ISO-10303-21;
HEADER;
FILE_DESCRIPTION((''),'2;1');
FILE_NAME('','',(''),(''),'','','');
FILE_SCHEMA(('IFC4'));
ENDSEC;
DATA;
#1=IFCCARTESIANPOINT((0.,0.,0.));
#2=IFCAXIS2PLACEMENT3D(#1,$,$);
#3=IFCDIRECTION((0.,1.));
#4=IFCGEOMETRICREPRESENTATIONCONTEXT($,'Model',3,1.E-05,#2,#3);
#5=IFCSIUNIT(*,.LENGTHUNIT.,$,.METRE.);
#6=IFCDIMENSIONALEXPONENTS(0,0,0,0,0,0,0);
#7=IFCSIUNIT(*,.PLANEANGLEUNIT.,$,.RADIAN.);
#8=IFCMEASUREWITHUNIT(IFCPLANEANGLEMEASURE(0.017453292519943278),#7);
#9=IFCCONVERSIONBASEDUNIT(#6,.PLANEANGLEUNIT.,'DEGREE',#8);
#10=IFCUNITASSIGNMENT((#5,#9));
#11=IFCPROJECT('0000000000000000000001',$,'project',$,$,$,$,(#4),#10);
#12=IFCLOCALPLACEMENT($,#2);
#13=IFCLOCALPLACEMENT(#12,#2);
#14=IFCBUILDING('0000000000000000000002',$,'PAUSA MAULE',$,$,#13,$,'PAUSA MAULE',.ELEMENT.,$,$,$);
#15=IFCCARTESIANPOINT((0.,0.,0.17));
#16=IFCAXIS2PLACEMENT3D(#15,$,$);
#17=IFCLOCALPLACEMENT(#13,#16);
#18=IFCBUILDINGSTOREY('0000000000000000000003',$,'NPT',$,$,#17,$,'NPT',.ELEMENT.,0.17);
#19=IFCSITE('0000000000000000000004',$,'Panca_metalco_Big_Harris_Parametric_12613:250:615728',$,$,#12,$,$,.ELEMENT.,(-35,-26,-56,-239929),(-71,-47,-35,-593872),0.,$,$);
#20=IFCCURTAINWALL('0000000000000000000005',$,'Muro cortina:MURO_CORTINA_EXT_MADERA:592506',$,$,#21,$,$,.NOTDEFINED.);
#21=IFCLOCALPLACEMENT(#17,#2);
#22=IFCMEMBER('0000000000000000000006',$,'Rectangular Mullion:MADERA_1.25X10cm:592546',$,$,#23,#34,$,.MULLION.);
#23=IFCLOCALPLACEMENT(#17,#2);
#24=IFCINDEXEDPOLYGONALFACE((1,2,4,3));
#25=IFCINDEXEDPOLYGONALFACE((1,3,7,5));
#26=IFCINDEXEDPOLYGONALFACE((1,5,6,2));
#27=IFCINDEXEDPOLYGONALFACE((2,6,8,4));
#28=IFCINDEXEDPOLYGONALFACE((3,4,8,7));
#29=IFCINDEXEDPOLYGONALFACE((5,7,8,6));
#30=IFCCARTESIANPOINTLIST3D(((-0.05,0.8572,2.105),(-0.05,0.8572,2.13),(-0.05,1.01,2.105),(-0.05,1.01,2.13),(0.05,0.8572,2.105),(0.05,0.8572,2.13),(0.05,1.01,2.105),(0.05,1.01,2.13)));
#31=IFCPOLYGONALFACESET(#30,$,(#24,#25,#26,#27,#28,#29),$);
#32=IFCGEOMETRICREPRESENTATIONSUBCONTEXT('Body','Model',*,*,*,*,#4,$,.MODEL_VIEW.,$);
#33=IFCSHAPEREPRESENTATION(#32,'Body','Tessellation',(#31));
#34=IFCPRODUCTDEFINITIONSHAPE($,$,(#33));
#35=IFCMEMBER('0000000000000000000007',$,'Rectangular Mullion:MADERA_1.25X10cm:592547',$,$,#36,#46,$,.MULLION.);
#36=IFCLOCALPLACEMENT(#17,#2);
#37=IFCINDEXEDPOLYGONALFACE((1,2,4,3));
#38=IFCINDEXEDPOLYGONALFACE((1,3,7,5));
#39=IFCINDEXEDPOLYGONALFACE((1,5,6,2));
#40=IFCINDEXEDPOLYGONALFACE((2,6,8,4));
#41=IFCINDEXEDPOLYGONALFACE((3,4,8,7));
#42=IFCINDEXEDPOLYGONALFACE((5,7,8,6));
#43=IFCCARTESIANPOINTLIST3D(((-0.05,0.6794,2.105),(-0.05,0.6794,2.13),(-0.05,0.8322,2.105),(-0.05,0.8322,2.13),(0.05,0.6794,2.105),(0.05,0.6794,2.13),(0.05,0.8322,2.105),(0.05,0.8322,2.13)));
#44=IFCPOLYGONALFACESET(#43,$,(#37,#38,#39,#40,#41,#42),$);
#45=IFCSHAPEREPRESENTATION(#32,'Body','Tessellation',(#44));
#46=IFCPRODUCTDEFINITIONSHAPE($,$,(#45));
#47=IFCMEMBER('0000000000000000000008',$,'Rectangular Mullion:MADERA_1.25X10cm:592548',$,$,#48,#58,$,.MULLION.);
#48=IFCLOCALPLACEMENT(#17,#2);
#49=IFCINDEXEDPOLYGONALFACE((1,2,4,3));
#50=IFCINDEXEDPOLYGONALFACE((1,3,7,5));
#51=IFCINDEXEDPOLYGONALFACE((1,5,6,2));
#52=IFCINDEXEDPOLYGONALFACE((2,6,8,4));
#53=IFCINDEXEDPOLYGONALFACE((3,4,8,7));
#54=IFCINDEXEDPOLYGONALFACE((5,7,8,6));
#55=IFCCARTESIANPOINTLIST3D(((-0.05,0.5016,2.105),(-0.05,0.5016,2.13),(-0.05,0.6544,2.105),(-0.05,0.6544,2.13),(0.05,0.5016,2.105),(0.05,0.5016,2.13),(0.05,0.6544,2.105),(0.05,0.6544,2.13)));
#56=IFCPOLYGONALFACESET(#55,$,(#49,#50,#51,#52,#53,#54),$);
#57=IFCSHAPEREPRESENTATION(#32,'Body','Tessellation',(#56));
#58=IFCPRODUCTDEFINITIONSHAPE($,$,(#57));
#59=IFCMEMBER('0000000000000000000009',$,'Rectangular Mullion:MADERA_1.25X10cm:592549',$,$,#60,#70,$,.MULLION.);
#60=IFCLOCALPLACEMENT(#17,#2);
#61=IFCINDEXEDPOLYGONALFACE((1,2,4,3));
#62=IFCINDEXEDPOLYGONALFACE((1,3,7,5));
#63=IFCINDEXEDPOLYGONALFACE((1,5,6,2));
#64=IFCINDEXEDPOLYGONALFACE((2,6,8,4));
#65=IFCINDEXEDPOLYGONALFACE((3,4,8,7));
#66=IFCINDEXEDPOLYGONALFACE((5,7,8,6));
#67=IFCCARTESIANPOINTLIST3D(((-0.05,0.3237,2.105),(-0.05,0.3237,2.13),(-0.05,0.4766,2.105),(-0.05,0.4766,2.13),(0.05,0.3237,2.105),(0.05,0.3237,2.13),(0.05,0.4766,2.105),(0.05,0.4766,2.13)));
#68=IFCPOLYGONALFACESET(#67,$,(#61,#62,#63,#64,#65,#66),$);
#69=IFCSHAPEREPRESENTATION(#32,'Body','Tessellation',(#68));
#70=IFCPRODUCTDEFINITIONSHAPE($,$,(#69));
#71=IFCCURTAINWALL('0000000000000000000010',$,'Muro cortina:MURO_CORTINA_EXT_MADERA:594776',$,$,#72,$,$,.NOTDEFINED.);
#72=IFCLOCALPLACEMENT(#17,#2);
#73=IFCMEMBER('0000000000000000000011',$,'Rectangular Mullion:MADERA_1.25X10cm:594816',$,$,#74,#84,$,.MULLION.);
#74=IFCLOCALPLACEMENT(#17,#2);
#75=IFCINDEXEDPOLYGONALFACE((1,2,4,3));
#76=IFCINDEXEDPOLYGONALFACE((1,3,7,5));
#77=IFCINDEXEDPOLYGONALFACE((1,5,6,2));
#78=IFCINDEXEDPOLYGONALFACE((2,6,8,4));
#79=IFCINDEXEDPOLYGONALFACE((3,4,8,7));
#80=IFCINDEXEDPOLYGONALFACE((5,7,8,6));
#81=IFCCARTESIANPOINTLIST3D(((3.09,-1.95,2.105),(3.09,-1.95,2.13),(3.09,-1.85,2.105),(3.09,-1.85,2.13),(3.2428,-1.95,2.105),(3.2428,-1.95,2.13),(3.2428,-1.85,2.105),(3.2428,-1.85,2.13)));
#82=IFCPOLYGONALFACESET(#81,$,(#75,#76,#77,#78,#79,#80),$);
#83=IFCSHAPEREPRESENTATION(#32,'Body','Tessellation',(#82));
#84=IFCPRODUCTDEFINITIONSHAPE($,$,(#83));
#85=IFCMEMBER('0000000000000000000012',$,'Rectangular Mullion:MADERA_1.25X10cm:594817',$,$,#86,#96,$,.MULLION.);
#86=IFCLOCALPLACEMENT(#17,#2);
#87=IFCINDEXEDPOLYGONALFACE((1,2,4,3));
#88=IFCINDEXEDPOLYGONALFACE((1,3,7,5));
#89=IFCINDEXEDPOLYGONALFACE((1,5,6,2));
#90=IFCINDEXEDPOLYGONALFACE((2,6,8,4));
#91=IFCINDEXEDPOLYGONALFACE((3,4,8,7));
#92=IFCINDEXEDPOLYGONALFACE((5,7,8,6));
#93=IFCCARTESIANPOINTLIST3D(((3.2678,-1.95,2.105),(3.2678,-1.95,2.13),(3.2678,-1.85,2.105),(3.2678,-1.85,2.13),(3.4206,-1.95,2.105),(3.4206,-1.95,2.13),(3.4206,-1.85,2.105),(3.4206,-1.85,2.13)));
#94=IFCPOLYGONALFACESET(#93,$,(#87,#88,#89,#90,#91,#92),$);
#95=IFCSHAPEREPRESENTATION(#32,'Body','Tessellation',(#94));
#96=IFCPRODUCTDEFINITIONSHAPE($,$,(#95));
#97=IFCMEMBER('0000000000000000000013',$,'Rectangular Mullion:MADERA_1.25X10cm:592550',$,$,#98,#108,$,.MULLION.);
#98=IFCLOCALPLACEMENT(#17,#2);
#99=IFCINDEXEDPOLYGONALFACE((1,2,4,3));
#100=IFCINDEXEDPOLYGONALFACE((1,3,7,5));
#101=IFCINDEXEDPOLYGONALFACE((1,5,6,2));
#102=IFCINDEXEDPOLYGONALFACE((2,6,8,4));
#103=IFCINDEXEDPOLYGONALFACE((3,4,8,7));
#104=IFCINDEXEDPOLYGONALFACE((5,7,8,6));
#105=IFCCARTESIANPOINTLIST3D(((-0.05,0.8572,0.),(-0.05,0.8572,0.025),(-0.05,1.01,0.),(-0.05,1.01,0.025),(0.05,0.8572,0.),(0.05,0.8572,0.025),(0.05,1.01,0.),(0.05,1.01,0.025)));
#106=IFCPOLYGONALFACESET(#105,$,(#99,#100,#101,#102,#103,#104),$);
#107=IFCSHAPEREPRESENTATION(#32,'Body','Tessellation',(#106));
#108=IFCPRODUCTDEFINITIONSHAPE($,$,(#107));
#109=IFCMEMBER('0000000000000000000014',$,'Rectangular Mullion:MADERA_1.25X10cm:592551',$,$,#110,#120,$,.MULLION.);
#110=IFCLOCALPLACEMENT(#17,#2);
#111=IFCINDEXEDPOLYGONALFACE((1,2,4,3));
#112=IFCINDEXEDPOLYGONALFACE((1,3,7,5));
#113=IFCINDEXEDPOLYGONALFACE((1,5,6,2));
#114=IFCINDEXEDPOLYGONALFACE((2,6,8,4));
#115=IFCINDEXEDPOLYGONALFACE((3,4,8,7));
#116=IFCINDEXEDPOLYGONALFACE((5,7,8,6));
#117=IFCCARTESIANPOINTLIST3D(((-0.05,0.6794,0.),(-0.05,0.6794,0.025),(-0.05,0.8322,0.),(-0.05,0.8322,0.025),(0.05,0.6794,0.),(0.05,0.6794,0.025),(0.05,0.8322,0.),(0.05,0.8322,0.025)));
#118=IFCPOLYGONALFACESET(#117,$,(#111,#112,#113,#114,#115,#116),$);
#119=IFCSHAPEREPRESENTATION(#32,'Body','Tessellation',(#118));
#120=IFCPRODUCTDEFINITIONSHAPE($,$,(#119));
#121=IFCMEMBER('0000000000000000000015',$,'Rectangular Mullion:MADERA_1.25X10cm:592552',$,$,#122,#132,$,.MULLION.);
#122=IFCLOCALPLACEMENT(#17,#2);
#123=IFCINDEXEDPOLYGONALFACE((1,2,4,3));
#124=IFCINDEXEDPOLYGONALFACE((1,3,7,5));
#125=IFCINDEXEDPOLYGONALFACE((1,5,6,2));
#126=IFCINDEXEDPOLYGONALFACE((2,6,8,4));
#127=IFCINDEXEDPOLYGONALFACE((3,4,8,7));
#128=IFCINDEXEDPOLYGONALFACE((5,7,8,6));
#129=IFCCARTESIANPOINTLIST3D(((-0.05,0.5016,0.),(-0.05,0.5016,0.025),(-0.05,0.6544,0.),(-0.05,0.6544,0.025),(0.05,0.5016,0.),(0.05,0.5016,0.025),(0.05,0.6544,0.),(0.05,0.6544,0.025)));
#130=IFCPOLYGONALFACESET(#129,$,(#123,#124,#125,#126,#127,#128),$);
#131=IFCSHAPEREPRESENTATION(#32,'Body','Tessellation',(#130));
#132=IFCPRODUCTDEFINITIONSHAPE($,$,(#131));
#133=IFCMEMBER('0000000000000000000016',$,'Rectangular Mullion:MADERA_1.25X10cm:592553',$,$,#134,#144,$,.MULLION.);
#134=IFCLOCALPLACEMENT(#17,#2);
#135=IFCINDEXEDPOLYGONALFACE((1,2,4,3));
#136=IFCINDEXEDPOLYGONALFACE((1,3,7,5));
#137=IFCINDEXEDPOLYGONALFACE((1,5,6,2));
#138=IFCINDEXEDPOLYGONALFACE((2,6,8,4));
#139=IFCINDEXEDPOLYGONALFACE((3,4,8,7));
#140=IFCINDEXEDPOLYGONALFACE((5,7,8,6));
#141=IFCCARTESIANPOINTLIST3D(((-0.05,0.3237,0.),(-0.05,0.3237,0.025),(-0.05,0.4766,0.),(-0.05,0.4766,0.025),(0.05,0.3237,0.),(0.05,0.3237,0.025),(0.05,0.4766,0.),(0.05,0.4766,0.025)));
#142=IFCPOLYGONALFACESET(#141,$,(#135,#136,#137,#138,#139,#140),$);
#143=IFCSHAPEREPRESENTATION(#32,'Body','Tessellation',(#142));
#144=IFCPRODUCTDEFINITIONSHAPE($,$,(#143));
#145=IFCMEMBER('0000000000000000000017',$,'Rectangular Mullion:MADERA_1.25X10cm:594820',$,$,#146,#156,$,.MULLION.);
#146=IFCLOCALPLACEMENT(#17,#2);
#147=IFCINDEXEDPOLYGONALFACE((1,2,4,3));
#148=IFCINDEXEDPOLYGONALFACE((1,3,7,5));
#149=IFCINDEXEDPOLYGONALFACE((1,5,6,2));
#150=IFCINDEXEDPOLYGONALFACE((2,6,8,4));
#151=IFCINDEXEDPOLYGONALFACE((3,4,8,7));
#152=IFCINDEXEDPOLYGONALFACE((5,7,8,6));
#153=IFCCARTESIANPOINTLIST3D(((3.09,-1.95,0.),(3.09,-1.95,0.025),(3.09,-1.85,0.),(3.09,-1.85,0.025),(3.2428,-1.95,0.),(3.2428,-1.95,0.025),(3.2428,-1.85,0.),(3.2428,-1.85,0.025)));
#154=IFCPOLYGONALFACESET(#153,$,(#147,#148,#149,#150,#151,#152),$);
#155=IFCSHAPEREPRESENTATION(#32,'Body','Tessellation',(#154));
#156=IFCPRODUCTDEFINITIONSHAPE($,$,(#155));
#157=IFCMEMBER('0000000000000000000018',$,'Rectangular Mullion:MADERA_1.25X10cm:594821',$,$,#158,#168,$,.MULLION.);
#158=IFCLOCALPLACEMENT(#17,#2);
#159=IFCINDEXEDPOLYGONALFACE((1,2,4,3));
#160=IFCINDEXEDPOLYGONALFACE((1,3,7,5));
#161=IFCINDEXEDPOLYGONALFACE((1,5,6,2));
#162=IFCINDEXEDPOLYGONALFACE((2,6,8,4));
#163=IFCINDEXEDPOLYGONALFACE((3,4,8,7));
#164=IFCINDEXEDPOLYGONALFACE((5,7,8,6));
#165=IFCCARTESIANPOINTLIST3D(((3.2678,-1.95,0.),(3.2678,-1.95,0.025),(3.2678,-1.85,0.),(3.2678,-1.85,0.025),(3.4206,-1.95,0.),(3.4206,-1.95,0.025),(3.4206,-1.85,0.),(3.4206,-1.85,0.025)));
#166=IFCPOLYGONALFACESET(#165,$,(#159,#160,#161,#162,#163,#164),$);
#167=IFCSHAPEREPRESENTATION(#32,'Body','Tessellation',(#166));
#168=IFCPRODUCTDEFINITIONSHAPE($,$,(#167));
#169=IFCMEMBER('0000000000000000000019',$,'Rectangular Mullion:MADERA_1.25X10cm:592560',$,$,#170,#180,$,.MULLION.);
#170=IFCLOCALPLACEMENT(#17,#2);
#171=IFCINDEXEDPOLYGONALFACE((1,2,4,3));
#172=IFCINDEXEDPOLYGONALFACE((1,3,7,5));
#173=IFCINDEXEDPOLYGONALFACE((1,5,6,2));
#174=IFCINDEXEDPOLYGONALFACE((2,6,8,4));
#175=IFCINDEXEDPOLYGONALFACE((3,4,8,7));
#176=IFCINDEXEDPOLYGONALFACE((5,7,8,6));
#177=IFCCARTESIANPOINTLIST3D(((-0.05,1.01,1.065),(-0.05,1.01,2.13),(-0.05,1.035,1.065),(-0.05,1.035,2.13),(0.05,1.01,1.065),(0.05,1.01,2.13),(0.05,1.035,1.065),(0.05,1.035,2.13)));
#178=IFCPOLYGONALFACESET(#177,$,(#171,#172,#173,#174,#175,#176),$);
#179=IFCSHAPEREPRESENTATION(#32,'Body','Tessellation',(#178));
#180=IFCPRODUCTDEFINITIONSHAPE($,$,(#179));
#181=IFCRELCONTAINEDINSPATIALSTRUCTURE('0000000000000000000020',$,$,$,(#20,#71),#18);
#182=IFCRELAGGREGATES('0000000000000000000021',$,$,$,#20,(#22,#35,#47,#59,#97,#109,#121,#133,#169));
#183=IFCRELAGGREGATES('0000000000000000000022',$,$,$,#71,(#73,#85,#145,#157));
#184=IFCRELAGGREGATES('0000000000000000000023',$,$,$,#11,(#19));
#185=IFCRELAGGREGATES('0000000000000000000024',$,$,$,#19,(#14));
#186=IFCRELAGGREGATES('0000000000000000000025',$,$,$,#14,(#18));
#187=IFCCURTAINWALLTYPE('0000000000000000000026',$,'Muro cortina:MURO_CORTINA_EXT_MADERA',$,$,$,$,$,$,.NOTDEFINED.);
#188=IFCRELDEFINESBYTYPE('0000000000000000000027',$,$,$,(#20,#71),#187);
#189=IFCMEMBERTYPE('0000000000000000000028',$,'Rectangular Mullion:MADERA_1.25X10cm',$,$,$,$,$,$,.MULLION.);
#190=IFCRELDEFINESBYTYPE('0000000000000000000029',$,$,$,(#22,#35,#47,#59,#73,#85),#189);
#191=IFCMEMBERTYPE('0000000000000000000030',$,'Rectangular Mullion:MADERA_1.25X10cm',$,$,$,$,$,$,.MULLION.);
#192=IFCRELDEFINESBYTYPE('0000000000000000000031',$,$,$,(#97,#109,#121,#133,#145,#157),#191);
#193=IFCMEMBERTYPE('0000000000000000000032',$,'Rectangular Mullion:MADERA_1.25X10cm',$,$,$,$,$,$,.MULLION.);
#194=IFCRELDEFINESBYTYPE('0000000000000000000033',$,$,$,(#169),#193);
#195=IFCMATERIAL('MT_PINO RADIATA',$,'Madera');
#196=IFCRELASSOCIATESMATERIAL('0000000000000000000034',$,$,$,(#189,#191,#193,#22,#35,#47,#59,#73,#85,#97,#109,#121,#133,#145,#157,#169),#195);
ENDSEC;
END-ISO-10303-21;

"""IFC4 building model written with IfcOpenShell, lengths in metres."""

from ifc_helpers import new_model, entity, si_unit, converted_unit, direction, frame, frame_2d, origin, place, context, subcontext, project, spatial, rectangle, extrude, source, transform, mapped, material, material_profile, profile_set, profile_usage, type_object, type_shapes, element, aggregate, save


model = new_model("IFC4")

# Units and contexts
model_context = context("Model", 3, precision=1e-05, world=origin(), true_north=direction((0.0, 1.0)))
body_context = subcontext(model_context, "Body", "Model", "MODEL_VIEW")
ifc_project = project(units=[si_unit("LENGTHUNIT", "METRE"), converted_unit("PLANEANGLEUNIT", "DEGREE", entity("IfcPlaneAngleMeasure", 0.017453292519943278), si_unit("PLANEANGLEUNIT", "RADIAN"), dimensions=[0, 0, 0, 0, 0, 0, 0])], contexts=[model_context])

# Site, building, storey
site_placement = place(None, origin())
site = spatial("IfcSite", under=ifc_project, at=site_placement, Name="Panca_metalco_Big_Harris_Parametric_12613:250:615728", CompositionType="ELEMENT", RefLatitude=(-35, -26, -56, -239929), RefLongitude=(-71, -47, -35, -593872), RefElevation=0.0)
building_placement = place(site_placement, origin())
building = spatial("IfcBuilding", under=site, at=building_placement, Name="PAUSA MAULE", LongName="PAUSA MAULE", CompositionType="ELEMENT")
storey_placement = place(building_placement, frame((0.0, 0.0, 0.17)))
storey = spatial("IfcBuildingStorey", under=building, at=storey_placement, Name="NPT", LongName="NPT", CompositionType="ELEMENT", Elevation=0.17)

# Curtain walls, members
curtain_wall_type = type_object("IfcCurtainWallType", Name="Muro cortina:MURO_CORTINA_EXT_MADERA", PredefinedType="NOTDEFINED")
curtain_wall_1_placement = place(storey_placement, frame((0.0, 0.0, -0.17)))
curtain_wall_1 = element("IfcCurtainWall", 1, at=curtain_wall_1_placement, inside=storey, type_object=curtain_wall_type, Name="Muro cortina:MURO_CORTINA_EXT_MADERA:592506", PredefinedType="NOTDEFINED")
ifc_material = material(Name="MT_PINO RADIATA", Category="Madera")
ifc_material_profile = material_profile(ifc_material, rectangle(XDim=0.025, YDim=0.1, at=frame_2d((0.0, 0.0), x_axis=(1.0, 0.0))), Name="MADERA_1.25X10cm")
ifc_profile_set = profile_set([ifc_material_profile], Name="MADERA_1.25X10cm")
ifc_profile_usage = profile_usage(ifc_profile_set)
member_type_1 = type_object("IfcMemberType", Name="Rectangular Mullion:MADERA_1.25X10cm", PredefinedType="MULLION", material=ifc_profile_set)
shared_shape_1 = source(origin(), body_context, "Body", "SweptSolid", [
    extrude(rectangle(XDim=0.025, YDim=0.1, at=frame_2d((0.0, 0.0), x_axis=(1.0, 0.0))), frame((-0.0125, 0.0, -0.1528), z_axis=(0.0, 0.0, 1.0), x_axis=(-1.0, 0.0, 0.0)), (0.0, 0.0, 1.0), 0.1528),
])
type_shapes(member_type_1, [shared_shape_1])
member_1_placement = place(curtain_wall_1_placement, frame((0.0, 0.8572, 2.3), z_axis=(0.0, -1.0, 0.0), x_axis=(0.0, 0.0, 1.0)))
member_1 = element("IfcMember", 2, at=member_1_placement, type_object=member_type_1, material=ifc_profile_usage, Name="Rectangular Mullion:MADERA_1.25X10cm:592546", PredefinedType="MULLION", context=body_context, shape_type="MappedRepresentation", body=[
    mapped(shared_shape_1, transform((0.0, 0.0, 0.0), scale=1.0)),
])
member_2_placement = place(curtain_wall_1_placement, frame((0.0, 0.6794, 2.3), z_axis=(0.0, -1.0, 0.0), x_axis=(0.0, 0.0, 1.0)))
member_2 = element("IfcMember", 3, at=member_2_placement, type_object=member_type_1, material=ifc_profile_usage, Name="Rectangular Mullion:MADERA_1.25X10cm:592547", PredefinedType="MULLION", context=body_context, shape_type="MappedRepresentation", body=[
    mapped(shared_shape_1, transform((0.0, 0.0, 0.0), scale=1.0)),
])
member_3_placement = place(curtain_wall_1_placement, frame((0.0, 0.5016, 2.3), z_axis=(0.0, -1.0, 0.0), x_axis=(0.0, 0.0, 1.0)))
member_3 = element("IfcMember", 4, at=member_3_placement, type_object=member_type_1, material=ifc_profile_usage, Name="Rectangular Mullion:MADERA_1.25X10cm:592548", PredefinedType="MULLION", context=body_context, shape_type="MappedRepresentation", body=[
    mapped(shared_shape_1, transform((0.0, 0.0, 0.0), scale=1.0)),
])
member_4_placement = place(curtain_wall_1_placement, frame((0.0, 0.3237, 2.3), z_axis=(0.0, -1.0, 0.0), x_axis=(0.0, 0.0, 1.0)))
member_4 = element("IfcMember", 5, at=member_4_placement, type_object=member_type_1, material=ifc_profile_usage, Name="Rectangular Mullion:MADERA_1.25X10cm:592549", PredefinedType="MULLION", context=body_context, shape_type="MappedRepresentation", body=[
    mapped(shared_shape_1, transform((0.0, 0.0, 0.0), scale=1.0)),
])
curtain_wall_2_placement = place(storey_placement, frame((0.0, 0.0, -0.17)))
curtain_wall_2 = element("IfcCurtainWall", 6, at=curtain_wall_2_placement, inside=storey, type_object=curtain_wall_type, Name="Muro cortina:MURO_CORTINA_EXT_MADERA:594776", PredefinedType="NOTDEFINED")
member_5_placement = place(curtain_wall_2_placement, frame((3.2428, -1.9, 2.3), z_axis=(1.0, 0.0, 0.0), x_axis=(0.0, 0.0, 1.0)))
member_5 = element("IfcMember", 7, at=member_5_placement, type_object=member_type_1, material=ifc_profile_usage, Name="Rectangular Mullion:MADERA_1.25X10cm:594816", PredefinedType="MULLION", context=body_context, shape_type="MappedRepresentation", body=[
    mapped(shared_shape_1, transform((0.0, 0.0, 0.0), scale=1.0)),
])
member_6_placement = place(curtain_wall_2_placement, frame((3.4206, -1.9, 2.3), z_axis=(1.0, 0.0, 0.0), x_axis=(0.0, 0.0, 1.0)))
member_6 = element("IfcMember", 8, at=member_6_placement, type_object=member_type_1, material=ifc_profile_usage, Name="Rectangular Mullion:MADERA_1.25X10cm:594817", PredefinedType="MULLION", context=body_context, shape_type="MappedRepresentation", body=[
    mapped(shared_shape_1, transform((0.0, 0.0, 0.0), scale=1.0)),
])

# Members
member_type_2 = type_object("IfcMemberType", Name="Rectangular Mullion:MADERA_1.25X10cm", PredefinedType="MULLION", material=ifc_profile_set)
shared_shape_2 = source(origin(), body_context, "Body", "SweptSolid", [
    extrude(rectangle(XDim=0.025, YDim=0.1, at=frame_2d((0.0, 0.0), x_axis=(1.0, 0.0))), frame((-0.0125, 0.0, -0.1528), z_axis=(0.0, 0.0, 1.0), x_axis=(-1.0, 0.0, 0.0)), (0.0, 0.0, 1.0), 0.1528),
])
type_shapes(member_type_2, [shared_shape_2])
member_7_placement = place(curtain_wall_1_placement, frame((0.0, 1.01, 0.17), z_axis=(0.0, 1.0, 0.0), x_axis=(0.0, 0.0, -1.0)))
member_7 = element("IfcMember", 9, at=member_7_placement, type_object=member_type_2, material=ifc_profile_usage, Name="Rectangular Mullion:MADERA_1.25X10cm:592550", PredefinedType="MULLION", context=body_context, shape_type="MappedRepresentation", body=[
    mapped(shared_shape_2, transform((0.0, 0.0, 0.0), scale=1.0)),
])
member_8_placement = place(curtain_wall_1_placement, frame((0.0, 0.8322, 0.17), z_axis=(0.0, 1.0, 0.0), x_axis=(0.0, 0.0, -1.0)))
member_8 = element("IfcMember", 10, at=member_8_placement, type_object=member_type_2, material=ifc_profile_usage, Name="Rectangular Mullion:MADERA_1.25X10cm:592551", PredefinedType="MULLION", context=body_context, shape_type="MappedRepresentation", body=[
    mapped(shared_shape_2, transform((0.0, 0.0, 0.0), scale=1.0)),
])
member_9_placement = place(curtain_wall_1_placement, frame((0.0, 0.6544, 0.17), z_axis=(0.0, 1.0, 0.0), x_axis=(0.0, 0.0, -1.0)))
member_9 = element("IfcMember", 11, at=member_9_placement, type_object=member_type_2, material=ifc_profile_usage, Name="Rectangular Mullion:MADERA_1.25X10cm:592552", PredefinedType="MULLION", context=body_context, shape_type="MappedRepresentation", body=[
    mapped(shared_shape_2, transform((0.0, 0.0, 0.0), scale=1.0)),
])
member_10_placement = place(curtain_wall_1_placement, frame((0.0, 0.4766, 0.17), z_axis=(0.0, 1.0, 0.0), x_axis=(0.0, 0.0, -1.0)))
member_10 = element("IfcMember", 12, at=member_10_placement, type_object=member_type_2, material=ifc_profile_usage, Name="Rectangular Mullion:MADERA_1.25X10cm:592553", PredefinedType="MULLION", context=body_context, shape_type="MappedRepresentation", body=[
    mapped(shared_shape_2, transform((0.0, 0.0, 0.0), scale=1.0)),
])
member_11_placement = place(curtain_wall_2_placement, frame((3.09, -1.9, 0.17), z_axis=(-1.0, 0.0, 0.0), x_axis=(0.0, 0.0, -1.0)))
member_11 = element("IfcMember", 13, at=member_11_placement, type_object=member_type_2, material=ifc_profile_usage, Name="Rectangular Mullion:MADERA_1.25X10cm:594820", PredefinedType="MULLION", context=body_context, shape_type="MappedRepresentation", body=[
    mapped(shared_shape_2, transform((0.0, 0.0, 0.0), scale=1.0)),
])
member_12_placement = place(curtain_wall_2_placement, frame((3.2678, -1.9, 0.17), z_axis=(-1.0, 0.0, 0.0), x_axis=(0.0, 0.0, -1.0)))
member_12 = element("IfcMember", 14, at=member_12_placement, type_object=member_type_2, material=ifc_profile_usage, Name="Rectangular Mullion:MADERA_1.25X10cm:594821", PredefinedType="MULLION", context=body_context, shape_type="MappedRepresentation", body=[
    mapped(shared_shape_2, transform((0.0, 0.0, 0.0), scale=1.0)),
])
member_type_3 = type_object("IfcMemberType", Name="Rectangular Mullion:MADERA_1.25X10cm", PredefinedType="MULLION", material=ifc_profile_set)
shared_shape_3 = source(origin(), body_context, "Body", "SweptSolid", [
    extrude(rectangle(XDim=0.025, YDim=0.1, at=frame_2d((0.0, 0.0), x_axis=(1.0, 0.0))), frame((-0.0125, 0.0, -1.065), z_axis=(0.0, 0.0, 1.0), x_axis=(-1.0, 0.0, 0.0)), (0.0, 0.0, 1.0), 1.065),
])
type_shapes(member_type_3, [shared_shape_3])
member_13_placement = place(curtain_wall_1_placement, frame((0.0, 1.035, 2.3), z_axis=(0.0, 0.0, 1.0), x_axis=(0.0, 1.0, 0.0)))
member_13 = element("IfcMember", 15, at=member_13_placement, type_object=member_type_3, material=ifc_profile_usage, Name="Rectangular Mullion:MADERA_1.25X10cm:592560", PredefinedType="MULLION", context=body_context, shape_type="MappedRepresentation", body=[
    mapped(shared_shape_3, transform((0.0, 0.0, 0.0), scale=1.0)),
])
aggregate(curtain_wall_1, [member_1, member_2, member_3, member_4, member_7, member_8, member_9, member_10, member_13])
aggregate(curtain_wall_2, [member_5, member_6, member_11, member_12])

save(model, "model.ifc")
